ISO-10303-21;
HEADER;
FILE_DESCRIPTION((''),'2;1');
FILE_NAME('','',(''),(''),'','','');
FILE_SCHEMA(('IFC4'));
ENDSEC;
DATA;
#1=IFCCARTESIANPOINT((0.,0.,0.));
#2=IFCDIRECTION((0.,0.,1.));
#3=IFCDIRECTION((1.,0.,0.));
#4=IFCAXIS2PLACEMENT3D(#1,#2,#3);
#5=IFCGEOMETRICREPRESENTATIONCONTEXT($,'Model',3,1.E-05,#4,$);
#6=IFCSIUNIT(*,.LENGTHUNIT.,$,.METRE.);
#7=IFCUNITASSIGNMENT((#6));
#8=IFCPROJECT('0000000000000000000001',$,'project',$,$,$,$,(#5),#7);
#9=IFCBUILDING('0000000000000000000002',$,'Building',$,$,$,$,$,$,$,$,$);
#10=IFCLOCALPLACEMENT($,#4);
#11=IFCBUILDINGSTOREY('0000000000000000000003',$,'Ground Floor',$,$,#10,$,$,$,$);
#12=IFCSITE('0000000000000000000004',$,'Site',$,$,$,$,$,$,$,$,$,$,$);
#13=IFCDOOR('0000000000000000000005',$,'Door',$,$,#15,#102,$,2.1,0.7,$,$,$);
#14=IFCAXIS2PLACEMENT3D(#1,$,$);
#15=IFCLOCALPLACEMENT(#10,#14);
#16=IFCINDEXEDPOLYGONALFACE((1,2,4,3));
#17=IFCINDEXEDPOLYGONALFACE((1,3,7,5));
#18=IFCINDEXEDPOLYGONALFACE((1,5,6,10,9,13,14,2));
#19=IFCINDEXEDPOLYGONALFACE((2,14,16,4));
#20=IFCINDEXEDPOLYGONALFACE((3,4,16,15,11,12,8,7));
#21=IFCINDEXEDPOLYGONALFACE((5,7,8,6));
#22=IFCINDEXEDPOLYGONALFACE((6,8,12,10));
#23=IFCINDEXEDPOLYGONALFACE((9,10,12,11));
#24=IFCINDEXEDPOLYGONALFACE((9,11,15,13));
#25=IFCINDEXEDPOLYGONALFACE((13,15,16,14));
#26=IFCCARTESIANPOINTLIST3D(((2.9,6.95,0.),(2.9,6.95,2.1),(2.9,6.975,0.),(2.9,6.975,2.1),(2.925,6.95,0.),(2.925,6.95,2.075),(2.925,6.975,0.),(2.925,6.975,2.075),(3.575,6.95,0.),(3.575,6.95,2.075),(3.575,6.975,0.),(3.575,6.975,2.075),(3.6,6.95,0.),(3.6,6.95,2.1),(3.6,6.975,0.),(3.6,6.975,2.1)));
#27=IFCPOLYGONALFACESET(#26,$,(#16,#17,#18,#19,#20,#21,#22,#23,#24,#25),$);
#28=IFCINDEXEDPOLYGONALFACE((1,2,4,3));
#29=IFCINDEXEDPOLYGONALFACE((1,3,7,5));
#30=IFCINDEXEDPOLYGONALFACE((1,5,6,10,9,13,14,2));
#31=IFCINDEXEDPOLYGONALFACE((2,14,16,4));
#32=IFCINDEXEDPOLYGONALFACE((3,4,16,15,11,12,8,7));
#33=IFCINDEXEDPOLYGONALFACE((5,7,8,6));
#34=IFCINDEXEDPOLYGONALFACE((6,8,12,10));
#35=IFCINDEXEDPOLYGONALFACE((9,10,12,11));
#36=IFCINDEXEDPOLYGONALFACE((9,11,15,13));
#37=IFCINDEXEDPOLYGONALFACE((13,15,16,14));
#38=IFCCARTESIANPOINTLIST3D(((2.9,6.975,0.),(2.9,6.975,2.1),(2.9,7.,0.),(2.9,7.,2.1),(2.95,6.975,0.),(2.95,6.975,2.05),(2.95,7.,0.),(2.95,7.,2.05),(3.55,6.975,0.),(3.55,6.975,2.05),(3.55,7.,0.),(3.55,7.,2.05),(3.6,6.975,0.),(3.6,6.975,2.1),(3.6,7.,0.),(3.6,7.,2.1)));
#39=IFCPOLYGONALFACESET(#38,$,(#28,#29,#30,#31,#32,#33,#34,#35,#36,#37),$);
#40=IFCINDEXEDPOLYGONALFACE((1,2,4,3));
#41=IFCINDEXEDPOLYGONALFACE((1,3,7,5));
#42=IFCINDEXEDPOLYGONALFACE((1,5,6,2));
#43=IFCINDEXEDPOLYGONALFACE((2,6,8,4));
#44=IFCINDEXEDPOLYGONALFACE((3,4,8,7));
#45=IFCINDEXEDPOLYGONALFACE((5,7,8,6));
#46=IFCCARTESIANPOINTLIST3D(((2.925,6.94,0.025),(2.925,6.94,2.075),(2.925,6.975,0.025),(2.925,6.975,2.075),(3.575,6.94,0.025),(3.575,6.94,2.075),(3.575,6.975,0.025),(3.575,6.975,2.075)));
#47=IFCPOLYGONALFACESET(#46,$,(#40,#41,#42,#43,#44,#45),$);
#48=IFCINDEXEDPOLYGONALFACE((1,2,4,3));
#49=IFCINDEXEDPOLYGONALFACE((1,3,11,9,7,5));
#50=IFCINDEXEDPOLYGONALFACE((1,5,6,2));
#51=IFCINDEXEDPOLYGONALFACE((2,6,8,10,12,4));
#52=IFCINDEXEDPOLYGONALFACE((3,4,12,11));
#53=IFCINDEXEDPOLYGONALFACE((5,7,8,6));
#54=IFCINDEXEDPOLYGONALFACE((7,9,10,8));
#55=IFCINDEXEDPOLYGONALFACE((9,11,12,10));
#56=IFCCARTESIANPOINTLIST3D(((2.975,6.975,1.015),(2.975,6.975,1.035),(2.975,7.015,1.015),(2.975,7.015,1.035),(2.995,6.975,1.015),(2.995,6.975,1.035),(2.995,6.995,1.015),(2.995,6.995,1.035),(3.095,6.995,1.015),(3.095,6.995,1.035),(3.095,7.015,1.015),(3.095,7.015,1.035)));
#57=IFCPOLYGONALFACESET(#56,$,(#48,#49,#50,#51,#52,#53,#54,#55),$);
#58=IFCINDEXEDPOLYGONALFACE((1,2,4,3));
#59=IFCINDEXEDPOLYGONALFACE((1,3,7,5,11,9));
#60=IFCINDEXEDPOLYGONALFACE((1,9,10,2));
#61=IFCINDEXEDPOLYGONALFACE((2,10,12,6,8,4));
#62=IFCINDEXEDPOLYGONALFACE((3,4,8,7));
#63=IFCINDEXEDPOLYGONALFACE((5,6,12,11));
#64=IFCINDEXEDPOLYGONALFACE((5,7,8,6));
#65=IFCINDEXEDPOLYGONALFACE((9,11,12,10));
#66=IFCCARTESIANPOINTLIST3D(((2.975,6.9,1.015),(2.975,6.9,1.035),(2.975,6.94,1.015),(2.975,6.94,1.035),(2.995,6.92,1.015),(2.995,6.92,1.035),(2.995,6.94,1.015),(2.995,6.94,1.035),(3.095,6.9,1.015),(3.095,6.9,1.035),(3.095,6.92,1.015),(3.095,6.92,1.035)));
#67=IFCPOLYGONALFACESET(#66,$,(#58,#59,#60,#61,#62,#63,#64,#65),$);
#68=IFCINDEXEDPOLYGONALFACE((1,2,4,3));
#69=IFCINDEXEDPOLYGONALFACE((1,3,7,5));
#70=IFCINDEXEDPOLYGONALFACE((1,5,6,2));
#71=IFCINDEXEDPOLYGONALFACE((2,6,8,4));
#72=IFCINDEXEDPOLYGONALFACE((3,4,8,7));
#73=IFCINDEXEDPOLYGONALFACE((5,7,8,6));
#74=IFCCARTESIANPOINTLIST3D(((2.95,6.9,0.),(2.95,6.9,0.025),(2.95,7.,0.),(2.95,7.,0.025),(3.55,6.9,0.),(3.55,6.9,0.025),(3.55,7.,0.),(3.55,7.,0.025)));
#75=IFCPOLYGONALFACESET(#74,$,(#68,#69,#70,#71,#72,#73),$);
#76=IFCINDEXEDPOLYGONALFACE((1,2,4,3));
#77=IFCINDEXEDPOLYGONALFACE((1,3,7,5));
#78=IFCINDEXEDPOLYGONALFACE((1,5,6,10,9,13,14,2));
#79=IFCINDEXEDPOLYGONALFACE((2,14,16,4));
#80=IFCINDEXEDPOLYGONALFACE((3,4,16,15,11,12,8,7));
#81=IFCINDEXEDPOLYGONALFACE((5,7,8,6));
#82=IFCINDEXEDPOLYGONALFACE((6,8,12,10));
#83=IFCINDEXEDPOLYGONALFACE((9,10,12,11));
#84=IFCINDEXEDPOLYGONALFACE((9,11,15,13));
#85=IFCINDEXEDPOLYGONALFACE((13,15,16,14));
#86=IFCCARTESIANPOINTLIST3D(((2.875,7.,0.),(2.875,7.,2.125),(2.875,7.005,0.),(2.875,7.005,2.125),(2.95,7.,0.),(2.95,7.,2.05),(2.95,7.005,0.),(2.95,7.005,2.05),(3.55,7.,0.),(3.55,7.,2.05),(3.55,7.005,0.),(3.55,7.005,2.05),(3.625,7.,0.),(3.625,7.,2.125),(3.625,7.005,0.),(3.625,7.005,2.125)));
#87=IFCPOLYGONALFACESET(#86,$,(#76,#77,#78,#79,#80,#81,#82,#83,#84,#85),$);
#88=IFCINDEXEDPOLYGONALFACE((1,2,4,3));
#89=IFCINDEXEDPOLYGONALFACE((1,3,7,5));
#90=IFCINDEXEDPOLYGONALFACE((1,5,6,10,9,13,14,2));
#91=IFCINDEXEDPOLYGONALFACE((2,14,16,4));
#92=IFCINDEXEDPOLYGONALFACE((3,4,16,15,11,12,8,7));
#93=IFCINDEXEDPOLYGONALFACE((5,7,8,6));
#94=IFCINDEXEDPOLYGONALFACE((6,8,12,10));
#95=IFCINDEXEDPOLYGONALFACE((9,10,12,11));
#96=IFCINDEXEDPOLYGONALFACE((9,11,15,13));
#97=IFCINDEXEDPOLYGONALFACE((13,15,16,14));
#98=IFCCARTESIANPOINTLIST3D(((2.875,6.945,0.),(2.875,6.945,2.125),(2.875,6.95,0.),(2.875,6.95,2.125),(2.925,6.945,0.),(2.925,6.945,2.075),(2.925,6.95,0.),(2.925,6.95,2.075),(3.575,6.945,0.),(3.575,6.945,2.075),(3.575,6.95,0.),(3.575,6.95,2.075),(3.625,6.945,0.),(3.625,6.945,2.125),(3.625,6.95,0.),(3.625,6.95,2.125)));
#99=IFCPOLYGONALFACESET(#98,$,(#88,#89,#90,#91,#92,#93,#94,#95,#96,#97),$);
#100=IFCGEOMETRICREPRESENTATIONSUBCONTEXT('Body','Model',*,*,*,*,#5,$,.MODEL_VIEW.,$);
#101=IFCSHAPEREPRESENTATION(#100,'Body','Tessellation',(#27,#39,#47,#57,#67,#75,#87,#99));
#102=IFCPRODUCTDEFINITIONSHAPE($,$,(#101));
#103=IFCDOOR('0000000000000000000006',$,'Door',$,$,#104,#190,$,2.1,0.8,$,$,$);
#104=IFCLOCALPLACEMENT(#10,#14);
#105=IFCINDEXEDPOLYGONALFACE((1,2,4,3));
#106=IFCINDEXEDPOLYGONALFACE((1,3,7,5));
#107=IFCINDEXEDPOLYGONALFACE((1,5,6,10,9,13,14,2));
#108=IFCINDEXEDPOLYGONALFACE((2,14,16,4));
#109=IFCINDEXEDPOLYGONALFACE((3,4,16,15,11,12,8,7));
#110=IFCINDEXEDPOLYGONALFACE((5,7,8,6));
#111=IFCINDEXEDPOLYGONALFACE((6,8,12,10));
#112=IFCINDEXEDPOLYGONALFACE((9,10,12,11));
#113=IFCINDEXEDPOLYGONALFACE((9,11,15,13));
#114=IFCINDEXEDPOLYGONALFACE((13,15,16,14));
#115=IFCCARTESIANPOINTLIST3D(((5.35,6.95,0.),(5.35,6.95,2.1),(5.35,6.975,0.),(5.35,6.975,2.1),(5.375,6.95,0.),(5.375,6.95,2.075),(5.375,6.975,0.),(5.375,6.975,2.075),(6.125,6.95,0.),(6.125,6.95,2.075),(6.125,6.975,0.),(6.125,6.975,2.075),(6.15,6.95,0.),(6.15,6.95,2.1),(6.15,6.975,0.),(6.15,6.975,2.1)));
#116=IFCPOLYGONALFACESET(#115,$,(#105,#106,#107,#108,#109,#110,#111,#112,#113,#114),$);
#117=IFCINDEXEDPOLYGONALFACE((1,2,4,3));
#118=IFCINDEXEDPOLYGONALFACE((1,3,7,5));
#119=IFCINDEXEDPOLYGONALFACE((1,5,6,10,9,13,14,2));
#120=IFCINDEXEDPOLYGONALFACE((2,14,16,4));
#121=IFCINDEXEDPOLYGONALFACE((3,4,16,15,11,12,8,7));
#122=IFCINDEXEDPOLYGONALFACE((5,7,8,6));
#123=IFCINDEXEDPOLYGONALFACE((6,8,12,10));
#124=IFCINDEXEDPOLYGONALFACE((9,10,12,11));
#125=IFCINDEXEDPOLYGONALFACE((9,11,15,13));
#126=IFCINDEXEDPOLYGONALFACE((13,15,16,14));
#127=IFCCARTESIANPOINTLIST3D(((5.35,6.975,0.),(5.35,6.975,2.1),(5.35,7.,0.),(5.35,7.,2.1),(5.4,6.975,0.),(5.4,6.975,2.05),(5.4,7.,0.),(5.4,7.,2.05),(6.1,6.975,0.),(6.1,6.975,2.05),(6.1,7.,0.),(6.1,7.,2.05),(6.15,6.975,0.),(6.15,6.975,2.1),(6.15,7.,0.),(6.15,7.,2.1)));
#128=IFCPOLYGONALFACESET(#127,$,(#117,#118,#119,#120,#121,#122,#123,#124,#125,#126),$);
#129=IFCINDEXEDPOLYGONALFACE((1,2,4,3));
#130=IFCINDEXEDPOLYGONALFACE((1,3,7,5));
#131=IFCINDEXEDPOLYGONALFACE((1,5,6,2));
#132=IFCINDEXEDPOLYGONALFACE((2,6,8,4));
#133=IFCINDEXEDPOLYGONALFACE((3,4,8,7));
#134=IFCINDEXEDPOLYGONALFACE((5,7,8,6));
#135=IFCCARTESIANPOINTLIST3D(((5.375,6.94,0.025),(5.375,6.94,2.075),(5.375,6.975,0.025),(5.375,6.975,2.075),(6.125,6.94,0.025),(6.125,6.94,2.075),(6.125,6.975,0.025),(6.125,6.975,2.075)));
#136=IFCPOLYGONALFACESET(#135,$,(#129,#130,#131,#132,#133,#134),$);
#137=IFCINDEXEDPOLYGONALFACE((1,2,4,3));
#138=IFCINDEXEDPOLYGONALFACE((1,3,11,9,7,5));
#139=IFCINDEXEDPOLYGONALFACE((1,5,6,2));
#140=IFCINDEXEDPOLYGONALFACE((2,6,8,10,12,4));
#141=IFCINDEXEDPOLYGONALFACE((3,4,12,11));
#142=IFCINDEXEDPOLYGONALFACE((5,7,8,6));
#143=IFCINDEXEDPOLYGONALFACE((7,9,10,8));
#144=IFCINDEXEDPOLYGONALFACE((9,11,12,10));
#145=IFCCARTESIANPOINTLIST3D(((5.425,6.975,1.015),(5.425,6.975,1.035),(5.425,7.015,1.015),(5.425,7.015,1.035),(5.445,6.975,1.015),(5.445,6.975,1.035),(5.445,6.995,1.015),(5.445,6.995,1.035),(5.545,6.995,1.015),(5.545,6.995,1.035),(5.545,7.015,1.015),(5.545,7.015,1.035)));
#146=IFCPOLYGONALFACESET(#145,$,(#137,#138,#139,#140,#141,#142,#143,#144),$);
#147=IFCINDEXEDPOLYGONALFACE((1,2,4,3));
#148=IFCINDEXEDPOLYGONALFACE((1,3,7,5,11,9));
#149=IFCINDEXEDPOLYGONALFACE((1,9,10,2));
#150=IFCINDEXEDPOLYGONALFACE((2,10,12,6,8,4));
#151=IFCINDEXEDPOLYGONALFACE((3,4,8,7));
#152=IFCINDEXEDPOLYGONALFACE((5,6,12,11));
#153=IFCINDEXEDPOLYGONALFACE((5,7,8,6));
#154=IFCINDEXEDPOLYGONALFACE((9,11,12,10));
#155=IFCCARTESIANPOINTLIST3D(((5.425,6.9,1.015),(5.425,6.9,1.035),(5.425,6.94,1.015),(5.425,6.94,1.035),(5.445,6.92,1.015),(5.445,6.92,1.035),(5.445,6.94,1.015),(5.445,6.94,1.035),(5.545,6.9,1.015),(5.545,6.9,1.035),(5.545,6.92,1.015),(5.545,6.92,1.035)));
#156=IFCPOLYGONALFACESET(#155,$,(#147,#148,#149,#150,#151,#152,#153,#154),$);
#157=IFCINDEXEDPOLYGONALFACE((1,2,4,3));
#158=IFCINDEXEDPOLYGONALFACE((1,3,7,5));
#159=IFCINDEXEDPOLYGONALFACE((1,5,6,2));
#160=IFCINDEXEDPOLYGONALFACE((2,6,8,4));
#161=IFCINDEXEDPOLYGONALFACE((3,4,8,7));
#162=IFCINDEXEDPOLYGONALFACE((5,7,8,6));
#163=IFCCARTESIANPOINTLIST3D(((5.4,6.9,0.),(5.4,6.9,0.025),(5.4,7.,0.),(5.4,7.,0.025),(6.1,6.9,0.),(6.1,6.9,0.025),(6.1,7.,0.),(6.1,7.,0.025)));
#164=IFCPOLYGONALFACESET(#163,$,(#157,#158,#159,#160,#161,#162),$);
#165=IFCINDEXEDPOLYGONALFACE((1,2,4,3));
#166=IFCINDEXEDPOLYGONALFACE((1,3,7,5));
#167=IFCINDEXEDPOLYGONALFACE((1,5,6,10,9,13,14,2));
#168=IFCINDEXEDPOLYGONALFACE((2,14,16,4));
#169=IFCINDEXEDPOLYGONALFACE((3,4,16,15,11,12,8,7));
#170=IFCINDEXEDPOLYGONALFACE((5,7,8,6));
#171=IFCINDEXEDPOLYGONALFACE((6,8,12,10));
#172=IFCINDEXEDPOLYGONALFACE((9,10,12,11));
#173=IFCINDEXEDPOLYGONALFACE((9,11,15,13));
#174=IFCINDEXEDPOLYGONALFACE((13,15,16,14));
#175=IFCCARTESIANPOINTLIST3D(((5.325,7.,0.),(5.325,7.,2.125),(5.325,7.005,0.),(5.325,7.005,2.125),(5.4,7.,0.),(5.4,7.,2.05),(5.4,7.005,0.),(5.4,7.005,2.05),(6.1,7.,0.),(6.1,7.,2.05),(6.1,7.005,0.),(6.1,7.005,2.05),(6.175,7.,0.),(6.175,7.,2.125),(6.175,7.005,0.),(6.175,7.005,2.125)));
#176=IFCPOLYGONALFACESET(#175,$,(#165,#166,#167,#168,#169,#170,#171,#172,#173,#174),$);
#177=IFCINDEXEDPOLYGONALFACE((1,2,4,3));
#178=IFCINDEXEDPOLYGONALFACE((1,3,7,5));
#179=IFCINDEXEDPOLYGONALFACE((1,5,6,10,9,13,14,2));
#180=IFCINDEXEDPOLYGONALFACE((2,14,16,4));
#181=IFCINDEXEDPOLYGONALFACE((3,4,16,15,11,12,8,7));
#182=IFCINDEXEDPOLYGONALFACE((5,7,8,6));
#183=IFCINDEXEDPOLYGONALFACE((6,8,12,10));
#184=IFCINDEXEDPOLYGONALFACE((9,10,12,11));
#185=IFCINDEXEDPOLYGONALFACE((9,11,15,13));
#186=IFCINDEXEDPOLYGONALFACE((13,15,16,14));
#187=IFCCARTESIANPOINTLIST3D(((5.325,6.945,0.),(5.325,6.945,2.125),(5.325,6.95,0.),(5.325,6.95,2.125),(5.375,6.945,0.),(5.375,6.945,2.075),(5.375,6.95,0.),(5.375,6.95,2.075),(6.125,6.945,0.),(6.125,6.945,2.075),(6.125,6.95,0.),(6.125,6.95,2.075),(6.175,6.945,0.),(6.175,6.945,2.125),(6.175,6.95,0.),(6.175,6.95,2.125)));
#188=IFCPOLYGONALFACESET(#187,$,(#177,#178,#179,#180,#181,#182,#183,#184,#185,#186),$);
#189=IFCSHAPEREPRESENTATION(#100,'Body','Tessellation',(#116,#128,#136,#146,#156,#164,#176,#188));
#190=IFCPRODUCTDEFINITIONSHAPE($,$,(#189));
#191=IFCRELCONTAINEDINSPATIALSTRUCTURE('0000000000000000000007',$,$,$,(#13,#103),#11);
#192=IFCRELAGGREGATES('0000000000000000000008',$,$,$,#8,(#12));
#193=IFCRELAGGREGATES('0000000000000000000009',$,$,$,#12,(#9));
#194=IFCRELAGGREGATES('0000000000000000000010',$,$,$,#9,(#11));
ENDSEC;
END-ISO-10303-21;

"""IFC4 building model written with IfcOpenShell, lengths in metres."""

from ifc_helpers import new_model, si_unit, frame, origin_with_axes, place, context, subcontext, project, spatial, line, indexed_curve, outline, extrude, element, save


model = new_model("IFC4")

# Units and contexts
model_context = context("Model", 3, precision=1e-05, world=origin_with_axes())
body_context = subcontext(model_context, "Body", "Model", "MODEL_VIEW")
ifc_project = project(units=[si_unit("LENGTHUNIT", "METRE")], contexts=[model_context])

# Site, building, storey
site = spatial("IfcSite", under=ifc_project, Name="Site")
building = spatial("IfcBuilding", under=site, Name="Building")
storey_placement = place(None, origin_with_axes())
storey = spatial("IfcBuildingStorey", under=building, at=storey_placement, Name="Ground Floor")

# Doors
door_1_placement = place(storey_placement, frame((3.6, 7.0, 0.0), z_axis=(0.0, 0.0, 1.0), x_axis=(-1.0, 0.0, 0.0)))
element("IfcDoor", 1, at=door_1_placement, inside=storey, Name="Door", OverallHeight=2.1, OverallWidth=0.7, context=body_context, shape_type="SweptSolid", body=[
    extrude(outline(indexed_curve([(0.0, 0.0), (0.0, 2.1), (0.7, 2.1), (0.7, 0.0), (0.675, 0.0), (0.675, 2.075), (0.025, 2.075), (0.025, 0.0)], segments=[line(1, 2, 3, 4, 5, 6, 7, 8, 1)])), frame((0.0, 0.025, 0.0), z_axis=(0.0, -1.0, 0.0), x_axis=(1.0, 0.0, 0.0)), (0.0, 0.0, -1.0), 0.025),
    extrude(outline(indexed_curve([(0.0, 0.0), (0.0, 2.1), (0.7, 2.1), (0.7, 0.0), (0.65, 0.0), (0.65, 2.05), (0.05, 2.05), (0.05, 0.0)], segments=[line(1, 2, 3, 4, 5, 6, 7, 8, 1)])), frame((0.0, 0.0, 0.0), z_axis=(0.0, -1.0, 0.0), x_axis=(1.0, 0.0, 0.0)), (0.0, 0.0, -1.0), 0.025),
    extrude(outline(indexed_curve([(0.0, 0.0), (0.65, 0.0), (0.65, 0.035), (0.0, 0.035)], segments=[line(1, 2, 3, 4, 1)])), frame((0.025, 0.025, 0.025), z_axis=(0.0, 0.0, 1.0), x_axis=(1.0, 0.0, 0.0)), (0.0, 0.0, 1.0), 2.05),
    extrude(outline(indexed_curve([(0.0, 0.0), (0.0, -0.04), (-0.12, -0.04), (-0.12, -0.02), (-0.02, -0.02), (-0.02, 0.0)], segments=[line(1, 2, 3, 4, 5, 6, 1)])), frame((0.625, 0.025, 1.015), z_axis=(0.0, 0.0, 1.0), x_axis=(1.0, 0.0, 0.0)), (0.0, 0.0, 1.0), 0.02),
    extrude(outline(indexed_curve([(0.0, 0.0), (0.0, 0.04), (-0.12, 0.04), (-0.12, 0.02), (-0.02, 0.02), (-0.02, 0.0)], segments=[line(1, 2, 3, 4, 5, 6, 1)])), frame((0.625, 0.06, 1.015), z_axis=(0.0, 0.0, 1.0), x_axis=(1.0, 0.0, 0.0)), (0.0, 0.0, 1.0), 0.02),
    extrude(outline(indexed_curve([(0.0, 0.0), (0.6, 0.0), (0.6, 0.1), (0.0, 0.1)], segments=[line(1, 2, 3, 4, 1)])), frame((0.05, 0.0, 0.0), z_axis=(0.0, 0.0, 1.0), x_axis=(1.0, 0.0, 0.0)), (0.0, 0.0, 1.0), 0.025),
    extrude(outline(indexed_curve([(0.0, 0.0), (0.0, 2.125), (0.75, 2.125), (0.75, 0.0), (0.675, 0.0), (0.675, 2.05), (0.075, 2.05), (0.075, 0.0)], segments=[line(1, 2, 3, 4, 5, 6, 7, 8, 1)])), frame((-0.025, -0.005, 0.0), z_axis=(0.0, -1.0, 0.0), x_axis=(1.0, 0.0, 0.0)), (0.0, 0.0, -1.0), 0.005),
    extrude(outline(indexed_curve([(0.0, 0.0), (0.0, 2.125), (0.75, 2.125), (0.75, 0.0), (0.7, 0.0), (0.7, 2.075), (0.05, 2.075), (0.05, 0.0)], segments=[line(1, 2, 3, 4, 5, 6, 7, 8, 1)])), frame((-0.025, 0.05, 0.0), z_axis=(0.0, -1.0, 0.0), x_axis=(1.0, 0.0, 0.0)), (0.0, 0.0, -1.0), 0.005),
])
door_2_placement = place(storey_placement, frame((6.15, 7.0, 0.0), z_axis=(0.0, 0.0, 1.0), x_axis=(-1.0, 0.0, 0.0)))
element("IfcDoor", 2, at=door_2_placement, inside=storey, Name="Door", OverallHeight=2.1, OverallWidth=0.8, context=body_context, shape_type="SweptSolid", body=[
    extrude(outline(indexed_curve([(0.0, 0.0), (0.0, 2.1), (0.8, 2.1), (0.8, 0.0), (0.775, 0.0), (0.775, 2.075), (0.025, 2.075), (0.025, 0.0)], segments=[line(1, 2, 3, 4, 5, 6, 7, 8, 1)])), frame((0.0, 0.025, 0.0), z_axis=(0.0, -1.0, 0.0), x_axis=(1.0, 0.0, 0.0)), (0.0, 0.0, -1.0), 0.025),
    extrude(outline(indexed_curve([(0.0, 0.0), (0.0, 2.1), (0.8, 2.1), (0.8, 0.0), (0.75, 0.0), (0.75, 2.05), (0.05, 2.05), (0.05, 0.0)], segments=[line(1, 2, 3, 4, 5, 6, 7, 8, 1)])), frame((0.0, 0.0, 0.0), z_axis=(0.0, -1.0, 0.0), x_axis=(1.0, 0.0, 0.0)), (0.0, 0.0, -1.0), 0.025),
    extrude(outline(indexed_curve([(0.0, 0.0), (0.75, 0.0), (0.75, 0.035), (0.0, 0.035)], segments=[line(1, 2, 3, 4, 1)])), frame((0.025, 0.025, 0.025), z_axis=(0.0, 0.0, 1.0), x_axis=(1.0, 0.0, 0.0)), (0.0, 0.0, 1.0), 2.05),
    extrude(outline(indexed_curve([(0.0, 0.0), (0.0, -0.04), (-0.12, -0.04), (-0.12, -0.02), (-0.02, -0.02), (-0.02, 0.0)], segments=[line(1, 2, 3, 4, 5, 6, 1)])), frame((0.725, 0.025, 1.015), z_axis=(0.0, 0.0, 1.0), x_axis=(1.0, 0.0, 0.0)), (0.0, 0.0, 1.0), 0.02),
    extrude(outline(indexed_curve([(0.0, 0.0), (0.0, 0.04), (-0.12, 0.04), (-0.12, 0.02), (-0.02, 0.02), (-0.02, 0.0)], segments=[line(1, 2, 3, 4, 5, 6, 1)])), frame((0.725, 0.06, 1.015), z_axis=(0.0, 0.0, 1.0), x_axis=(1.0, 0.0, 0.0)), (0.0, 0.0, 1.0), 0.02),
    extrude(outline(indexed_curve([(0.0, 0.0), (0.7, 0.0), (0.7, 0.1), (0.0, 0.1)], segments=[line(1, 2, 3, 4, 1)])), frame((0.05, 0.0, 0.0), z_axis=(0.0, 0.0, 1.0), x_axis=(1.0, 0.0, 0.0)), (0.0, 0.0, 1.0), 0.025),
    extrude(outline(indexed_curve([(0.0, 0.0), (0.0, 2.125), (0.85, 2.125), (0.85, 0.0), (0.775, 0.0), (0.775, 2.05), (0.075, 2.05), (0.075, 0.0)], segments=[line(1, 2, 3, 4, 5, 6, 7, 8, 1)])), frame((-0.025, -0.005, 0.0), z_axis=(0.0, -1.0, 0.0), x_axis=(1.0, 0.0, 0.0)), (0.0, 0.0, -1.0), 0.005),
    extrude(outline(indexed_curve([(0.0, 0.0), (0.0, 2.125), (0.85, 2.125), (0.85, 0.0), (0.8, 0.0), (0.8, 2.075), (0.05, 2.075), (0.05, 0.0)], segments=[line(1, 2, 3, 4, 5, 6, 7, 8, 1)])), frame((-0.025, 0.05, 0.0), z_axis=(0.0, -1.0, 0.0), x_axis=(1.0, 0.0, 0.0)), (0.0, 0.0, -1.0), 0.005),
])

save(model, "model.ifc")
